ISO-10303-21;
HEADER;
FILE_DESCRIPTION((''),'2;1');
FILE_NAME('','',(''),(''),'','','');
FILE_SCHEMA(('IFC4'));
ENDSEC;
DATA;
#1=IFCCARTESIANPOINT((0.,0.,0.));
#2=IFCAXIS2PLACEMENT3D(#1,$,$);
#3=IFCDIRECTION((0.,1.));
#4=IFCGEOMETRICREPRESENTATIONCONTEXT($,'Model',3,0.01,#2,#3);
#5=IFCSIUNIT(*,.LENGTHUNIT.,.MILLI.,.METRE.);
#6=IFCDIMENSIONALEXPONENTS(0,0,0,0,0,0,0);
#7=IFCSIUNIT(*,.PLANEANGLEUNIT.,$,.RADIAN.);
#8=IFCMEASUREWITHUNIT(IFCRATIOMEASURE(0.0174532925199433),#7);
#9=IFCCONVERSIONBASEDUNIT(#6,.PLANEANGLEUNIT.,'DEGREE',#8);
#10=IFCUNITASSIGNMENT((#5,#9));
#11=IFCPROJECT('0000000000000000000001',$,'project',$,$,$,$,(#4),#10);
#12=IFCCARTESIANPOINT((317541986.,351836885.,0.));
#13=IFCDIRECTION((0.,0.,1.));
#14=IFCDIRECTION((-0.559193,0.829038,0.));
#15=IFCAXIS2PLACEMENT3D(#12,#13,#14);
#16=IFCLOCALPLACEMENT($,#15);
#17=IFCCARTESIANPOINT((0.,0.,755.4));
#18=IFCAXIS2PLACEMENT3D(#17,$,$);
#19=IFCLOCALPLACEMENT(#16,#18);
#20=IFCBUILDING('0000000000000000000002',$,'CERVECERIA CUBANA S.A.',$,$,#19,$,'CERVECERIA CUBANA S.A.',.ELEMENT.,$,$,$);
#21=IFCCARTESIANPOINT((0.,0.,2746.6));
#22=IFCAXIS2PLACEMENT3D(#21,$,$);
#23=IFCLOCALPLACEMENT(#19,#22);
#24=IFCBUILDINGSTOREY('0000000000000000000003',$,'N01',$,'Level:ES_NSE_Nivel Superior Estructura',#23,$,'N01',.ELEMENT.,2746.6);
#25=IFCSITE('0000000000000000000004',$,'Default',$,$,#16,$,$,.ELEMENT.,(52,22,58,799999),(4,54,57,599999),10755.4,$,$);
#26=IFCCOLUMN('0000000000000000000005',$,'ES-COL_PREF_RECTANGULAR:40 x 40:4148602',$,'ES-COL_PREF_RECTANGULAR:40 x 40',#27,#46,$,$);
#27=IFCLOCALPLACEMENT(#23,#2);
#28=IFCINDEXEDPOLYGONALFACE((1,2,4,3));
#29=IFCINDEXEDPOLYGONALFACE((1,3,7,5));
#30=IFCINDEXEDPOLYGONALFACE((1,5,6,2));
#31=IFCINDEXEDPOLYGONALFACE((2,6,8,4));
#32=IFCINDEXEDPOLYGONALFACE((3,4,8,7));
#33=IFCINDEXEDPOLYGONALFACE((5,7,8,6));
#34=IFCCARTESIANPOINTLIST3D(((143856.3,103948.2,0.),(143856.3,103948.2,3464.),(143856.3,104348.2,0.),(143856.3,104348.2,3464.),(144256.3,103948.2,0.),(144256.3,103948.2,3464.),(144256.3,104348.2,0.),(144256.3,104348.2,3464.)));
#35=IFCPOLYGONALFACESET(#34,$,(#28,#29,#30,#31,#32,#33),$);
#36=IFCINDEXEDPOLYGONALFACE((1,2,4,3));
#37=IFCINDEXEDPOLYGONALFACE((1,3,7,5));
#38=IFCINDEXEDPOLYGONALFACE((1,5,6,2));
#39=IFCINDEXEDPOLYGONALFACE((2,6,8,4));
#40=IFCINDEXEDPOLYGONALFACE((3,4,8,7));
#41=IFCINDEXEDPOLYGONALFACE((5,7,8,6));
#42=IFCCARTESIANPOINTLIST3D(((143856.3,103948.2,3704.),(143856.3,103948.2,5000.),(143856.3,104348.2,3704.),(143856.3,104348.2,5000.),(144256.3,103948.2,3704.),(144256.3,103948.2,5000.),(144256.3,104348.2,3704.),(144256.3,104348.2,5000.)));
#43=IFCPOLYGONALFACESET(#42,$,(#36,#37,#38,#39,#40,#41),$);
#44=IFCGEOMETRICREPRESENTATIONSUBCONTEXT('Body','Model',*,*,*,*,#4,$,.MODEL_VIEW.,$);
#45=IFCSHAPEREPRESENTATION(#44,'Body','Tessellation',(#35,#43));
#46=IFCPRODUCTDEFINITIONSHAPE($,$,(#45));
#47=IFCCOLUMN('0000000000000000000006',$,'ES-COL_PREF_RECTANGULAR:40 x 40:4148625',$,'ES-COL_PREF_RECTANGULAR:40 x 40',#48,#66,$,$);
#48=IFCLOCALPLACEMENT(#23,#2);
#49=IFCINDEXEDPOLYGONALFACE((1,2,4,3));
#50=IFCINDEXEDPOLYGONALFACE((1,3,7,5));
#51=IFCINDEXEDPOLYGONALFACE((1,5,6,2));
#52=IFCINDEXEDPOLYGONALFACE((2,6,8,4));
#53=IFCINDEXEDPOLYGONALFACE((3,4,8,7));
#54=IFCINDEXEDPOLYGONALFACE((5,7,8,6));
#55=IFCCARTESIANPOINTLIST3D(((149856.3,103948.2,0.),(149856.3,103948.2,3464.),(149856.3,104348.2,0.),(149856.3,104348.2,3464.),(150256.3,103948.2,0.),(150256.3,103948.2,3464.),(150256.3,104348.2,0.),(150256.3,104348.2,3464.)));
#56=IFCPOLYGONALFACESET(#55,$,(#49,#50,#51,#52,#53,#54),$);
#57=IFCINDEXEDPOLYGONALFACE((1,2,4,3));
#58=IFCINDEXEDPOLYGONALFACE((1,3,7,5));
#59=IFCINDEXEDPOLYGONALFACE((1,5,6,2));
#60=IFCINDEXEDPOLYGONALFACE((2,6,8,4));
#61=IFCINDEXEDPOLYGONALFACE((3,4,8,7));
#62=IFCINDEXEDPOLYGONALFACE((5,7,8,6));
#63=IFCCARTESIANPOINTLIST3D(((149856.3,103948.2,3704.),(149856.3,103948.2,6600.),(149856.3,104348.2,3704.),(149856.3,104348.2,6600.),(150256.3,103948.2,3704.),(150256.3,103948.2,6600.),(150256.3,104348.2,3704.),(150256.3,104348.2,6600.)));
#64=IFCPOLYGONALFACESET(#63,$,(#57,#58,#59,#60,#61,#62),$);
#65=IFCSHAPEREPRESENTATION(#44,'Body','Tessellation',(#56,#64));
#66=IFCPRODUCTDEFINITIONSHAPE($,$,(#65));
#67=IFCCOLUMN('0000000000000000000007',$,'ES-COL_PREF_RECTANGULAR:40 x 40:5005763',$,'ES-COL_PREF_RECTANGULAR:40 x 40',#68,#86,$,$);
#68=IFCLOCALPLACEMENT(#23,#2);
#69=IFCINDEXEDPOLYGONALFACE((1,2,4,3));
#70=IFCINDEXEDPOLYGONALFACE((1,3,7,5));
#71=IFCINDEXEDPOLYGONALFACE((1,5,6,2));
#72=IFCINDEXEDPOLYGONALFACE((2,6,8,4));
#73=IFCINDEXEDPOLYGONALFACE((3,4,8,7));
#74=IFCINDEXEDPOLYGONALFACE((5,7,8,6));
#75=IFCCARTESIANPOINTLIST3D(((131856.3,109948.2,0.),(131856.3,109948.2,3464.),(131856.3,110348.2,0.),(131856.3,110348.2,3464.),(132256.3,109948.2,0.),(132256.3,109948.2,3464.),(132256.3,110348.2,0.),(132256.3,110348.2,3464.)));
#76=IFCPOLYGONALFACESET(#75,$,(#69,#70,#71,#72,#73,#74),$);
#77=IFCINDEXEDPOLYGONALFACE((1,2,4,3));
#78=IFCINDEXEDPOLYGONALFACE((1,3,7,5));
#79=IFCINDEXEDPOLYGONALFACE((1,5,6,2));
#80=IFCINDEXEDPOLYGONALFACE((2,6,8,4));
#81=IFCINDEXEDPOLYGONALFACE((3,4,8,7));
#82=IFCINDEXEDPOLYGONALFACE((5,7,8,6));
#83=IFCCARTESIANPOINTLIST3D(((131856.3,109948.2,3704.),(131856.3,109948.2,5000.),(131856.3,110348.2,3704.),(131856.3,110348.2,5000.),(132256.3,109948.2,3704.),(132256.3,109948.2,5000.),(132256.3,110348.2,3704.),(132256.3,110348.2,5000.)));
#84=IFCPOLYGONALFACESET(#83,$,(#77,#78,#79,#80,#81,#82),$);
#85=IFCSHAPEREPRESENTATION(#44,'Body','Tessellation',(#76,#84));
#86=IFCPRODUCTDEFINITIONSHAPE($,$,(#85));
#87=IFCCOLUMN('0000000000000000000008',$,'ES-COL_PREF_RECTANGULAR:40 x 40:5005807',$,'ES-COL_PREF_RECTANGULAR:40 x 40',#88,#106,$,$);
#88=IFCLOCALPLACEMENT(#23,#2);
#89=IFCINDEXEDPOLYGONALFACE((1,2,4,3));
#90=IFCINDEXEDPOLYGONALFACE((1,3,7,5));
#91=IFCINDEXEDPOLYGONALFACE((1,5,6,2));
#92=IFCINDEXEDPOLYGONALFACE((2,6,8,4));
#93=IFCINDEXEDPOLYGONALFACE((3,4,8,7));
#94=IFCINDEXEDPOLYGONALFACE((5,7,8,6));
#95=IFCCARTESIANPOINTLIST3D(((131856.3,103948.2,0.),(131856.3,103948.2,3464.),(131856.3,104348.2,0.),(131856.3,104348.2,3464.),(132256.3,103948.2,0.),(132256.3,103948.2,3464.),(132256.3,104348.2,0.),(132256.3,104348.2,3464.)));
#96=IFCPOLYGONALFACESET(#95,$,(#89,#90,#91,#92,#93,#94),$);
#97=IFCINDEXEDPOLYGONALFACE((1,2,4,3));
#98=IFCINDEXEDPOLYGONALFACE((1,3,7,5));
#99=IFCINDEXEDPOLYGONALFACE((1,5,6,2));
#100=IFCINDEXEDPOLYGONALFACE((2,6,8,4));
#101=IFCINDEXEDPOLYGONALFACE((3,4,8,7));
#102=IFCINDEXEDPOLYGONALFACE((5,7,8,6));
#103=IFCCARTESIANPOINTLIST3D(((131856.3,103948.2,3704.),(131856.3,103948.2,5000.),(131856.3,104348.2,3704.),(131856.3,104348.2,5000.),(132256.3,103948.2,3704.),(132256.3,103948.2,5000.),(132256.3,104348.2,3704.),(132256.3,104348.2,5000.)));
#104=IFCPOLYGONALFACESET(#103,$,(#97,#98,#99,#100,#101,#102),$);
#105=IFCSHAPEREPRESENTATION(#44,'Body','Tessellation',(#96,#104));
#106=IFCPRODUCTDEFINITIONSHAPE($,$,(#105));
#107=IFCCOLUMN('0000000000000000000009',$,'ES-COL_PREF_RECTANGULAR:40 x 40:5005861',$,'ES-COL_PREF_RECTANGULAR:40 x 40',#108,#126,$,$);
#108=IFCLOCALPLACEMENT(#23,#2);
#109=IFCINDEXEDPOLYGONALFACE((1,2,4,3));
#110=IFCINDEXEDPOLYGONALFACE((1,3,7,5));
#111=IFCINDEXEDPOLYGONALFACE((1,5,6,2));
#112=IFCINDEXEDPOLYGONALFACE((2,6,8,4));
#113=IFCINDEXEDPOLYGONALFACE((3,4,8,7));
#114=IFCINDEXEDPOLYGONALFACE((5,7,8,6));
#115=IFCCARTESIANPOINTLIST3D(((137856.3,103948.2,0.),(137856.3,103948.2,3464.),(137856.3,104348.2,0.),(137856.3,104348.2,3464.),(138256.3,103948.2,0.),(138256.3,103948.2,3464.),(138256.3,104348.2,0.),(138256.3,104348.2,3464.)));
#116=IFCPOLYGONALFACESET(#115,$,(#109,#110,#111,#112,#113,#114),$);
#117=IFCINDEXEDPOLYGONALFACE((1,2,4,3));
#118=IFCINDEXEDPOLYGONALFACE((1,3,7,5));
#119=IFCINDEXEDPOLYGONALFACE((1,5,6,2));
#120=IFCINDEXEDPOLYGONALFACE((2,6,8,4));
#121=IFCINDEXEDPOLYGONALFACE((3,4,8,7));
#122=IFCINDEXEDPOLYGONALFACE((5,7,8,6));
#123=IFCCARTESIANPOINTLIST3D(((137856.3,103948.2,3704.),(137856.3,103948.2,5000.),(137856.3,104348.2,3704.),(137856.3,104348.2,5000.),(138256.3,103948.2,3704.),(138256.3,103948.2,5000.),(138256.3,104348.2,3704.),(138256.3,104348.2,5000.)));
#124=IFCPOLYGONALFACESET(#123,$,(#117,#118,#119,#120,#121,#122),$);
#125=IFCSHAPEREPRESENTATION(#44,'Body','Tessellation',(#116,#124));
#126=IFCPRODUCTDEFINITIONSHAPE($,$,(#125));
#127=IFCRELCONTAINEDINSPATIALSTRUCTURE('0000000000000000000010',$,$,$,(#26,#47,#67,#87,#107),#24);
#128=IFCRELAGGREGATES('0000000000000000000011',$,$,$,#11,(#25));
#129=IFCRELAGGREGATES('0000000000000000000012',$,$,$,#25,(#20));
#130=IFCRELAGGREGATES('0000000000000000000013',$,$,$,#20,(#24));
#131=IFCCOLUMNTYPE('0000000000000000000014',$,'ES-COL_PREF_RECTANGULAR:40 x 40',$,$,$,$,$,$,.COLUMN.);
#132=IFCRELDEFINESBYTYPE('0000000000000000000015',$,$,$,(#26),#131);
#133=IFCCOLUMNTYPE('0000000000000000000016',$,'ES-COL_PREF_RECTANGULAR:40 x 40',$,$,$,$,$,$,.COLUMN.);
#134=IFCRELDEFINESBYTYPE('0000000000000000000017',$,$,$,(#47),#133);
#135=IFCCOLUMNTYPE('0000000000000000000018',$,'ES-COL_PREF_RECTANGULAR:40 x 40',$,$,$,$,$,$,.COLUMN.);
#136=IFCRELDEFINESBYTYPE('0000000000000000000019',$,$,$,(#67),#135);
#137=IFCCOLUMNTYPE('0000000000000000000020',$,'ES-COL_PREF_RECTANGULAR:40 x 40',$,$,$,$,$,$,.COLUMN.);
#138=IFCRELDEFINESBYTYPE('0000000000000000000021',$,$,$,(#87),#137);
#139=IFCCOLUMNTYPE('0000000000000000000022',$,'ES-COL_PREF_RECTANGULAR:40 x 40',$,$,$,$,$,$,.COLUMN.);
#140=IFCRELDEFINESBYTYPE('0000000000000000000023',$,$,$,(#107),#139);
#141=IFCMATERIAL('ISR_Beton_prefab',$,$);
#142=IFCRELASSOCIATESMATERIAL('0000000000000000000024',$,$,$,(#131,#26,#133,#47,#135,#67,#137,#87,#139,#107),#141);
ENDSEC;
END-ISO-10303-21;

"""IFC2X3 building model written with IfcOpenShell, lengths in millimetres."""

from ifc_helpers import new_model, entity, si_unit, converted_unit, direction, frame, frame_2d, origin, origin_2d_with_axis, place, context, subcontext, project, spatial, rectangle, extrude, source, transform, mapped, material, type_object, type_shapes, element, save


model = new_model("IFC2X3")

# Units and contexts
model_context = context("Model", 3, precision=0.01, world=origin(), true_north=direction((0.0, 1.0)))
body_context = subcontext(model_context, "Body", "Model", "MODEL_VIEW")
ifc_project = project(units=[si_unit("LENGTHUNIT", "METRE", prefix="MILLI"), converted_unit("PLANEANGLEUNIT", "DEGREE", entity("IfcRatioMeasure", 0.0174532925199433), si_unit("PLANEANGLEUNIT", "RADIAN"), dimensions=[0, 0, 0, 0, 0, 0, 0])], contexts=[model_context])

# Site, building, storey
site_placement = place(None, frame((317541986.0, 351836885.0, 0.0), z_axis=(0.0, 0.0, 1.0), x_axis=(-0.559193, 0.829038, 0.0)))
site = spatial("IfcSite", under=ifc_project, at=site_placement, Name="Default", CompositionType="ELEMENT", RefLatitude=(52, 22, 58, 799999), RefLongitude=(4, 54, 57, 599999), RefElevation=10755.4)
building_placement = place(site_placement, frame((0.0, 0.0, 755.4)))
building = spatial("IfcBuilding", under=site, at=building_placement, Name="CERVECERIA CUBANA S.A.", LongName="CERVECERIA CUBANA S.A.", CompositionType="ELEMENT")
storey_placement = place(building_placement, frame((0.0, 0.0, 2746.6)))
storey = spatial("IfcBuildingStorey", under=building, at=storey_placement, Name="N01", ObjectType="Level:ES_NSE_Nivel Superior Estructura", LongName="N01", CompositionType="ELEMENT", Elevation=2746.6)

# Columns
ifc_material_1 = material(Name="ISR_Beton_prefab")
column_type_1 = type_object("IfcColumnType", Name="ES-COL_PREF_RECTANGULAR:40 x 40", PredefinedType="COLUMN", material=ifc_material_1)
shared_shape_1 = source(origin(), body_context, "Body", "SweptSolid", [
    extrude(rectangle(XDim=400.0, YDim=400.0, at=frame_2d((0.0, 0.0), x_axis=(1.0, 0.0))), frame((144056.3, 104148.2, 2746.6), z_axis=(0.0, 0.0, 1.0), x_axis=(0.0, -1.0, 0.0)), (0.0, 0.0, 1.0), 3464.0),
    extrude(rectangle(XDim=400.0, YDim=400.0, at=frame_2d((0.0, 0.0), x_axis=(1.0, 0.0))), frame((144056.3, 104148.2, 6450.6), z_axis=(0.0, 0.0, 1.0), x_axis=(0.0, -1.0, 0.0)), (0.0, 0.0, 1.0), 1296.0),
])
type_shapes(column_type_1, [shared_shape_1])
column_1_placement = place(storey_placement, frame((0.0, 0.0, -2746.6)))
element("IfcColumn", 1, at=column_1_placement, inside=storey, type_object=column_type_1, material=ifc_material_1, Name="ES-COL_PREF_RECTANGULAR:40 x 40:4148602", ObjectType="ES-COL_PREF_RECTANGULAR:40 x 40", context=body_context, shape_type="MappedRepresentation", body=[
    mapped(shared_shape_1, transform((0.0, 0.0, 0.0), scale=1.0)),
])
column_type_2 = type_object("IfcColumnType", Name="ES-COL_PREF_RECTANGULAR:40 x 40", PredefinedType="COLUMN", material=ifc_material_1)
shared_shape_2 = source(origin(), body_context, "Body", "SweptSolid", [
    extrude(rectangle(XDim=400.0, YDim=400.0, at=origin_2d_with_axis()), frame((150056.3, 104148.2, 2746.6), z_axis=(0.0, 0.0, 1.0), x_axis=(0.0, -1.0, 0.0)), (0.0, 0.0, 1.0), 3464.0),
    extrude(rectangle(XDim=400.0, YDim=400.0, at=origin_2d_with_axis()), frame((150056.3, 104148.2, 6450.6), z_axis=(0.0, 0.0, 1.0), x_axis=(0.0, -1.0, 0.0)), (0.0, 0.0, 1.0), 2896.0),
])
type_shapes(column_type_2, [shared_shape_2])
column_2_placement = place(storey_placement, frame((0.0, 0.0, -2746.6)))
element("IfcColumn", 2, at=column_2_placement, inside=storey, type_object=column_type_2, material=ifc_material_1, Name="ES-COL_PREF_RECTANGULAR:40 x 40:4148625", ObjectType="ES-COL_PREF_RECTANGULAR:40 x 40", context=body_context, shape_type="MappedRepresentation", body=[
    mapped(shared_shape_2, transform((0.0, 0.0, 0.0), scale=1.0)),
])
column_type_3 = type_object("IfcColumnType", Name="ES-COL_PREF_RECTANGULAR:40 x 40", PredefinedType="COLUMN", material=ifc_material_1)
shared_shape_3 = source(origin(), body_context, "Body", "SweptSolid", [
    extrude(rectangle(XDim=400.0, YDim=400.0, at=frame_2d((0.0, 0.0), x_axis=(1.0, 0.0))), frame((132056.3, 110148.2, 2746.6), z_axis=(0.0, 0.0, 1.0), x_axis=(0.0, -1.0, 0.0)), (0.0, 0.0, 1.0), 3464.0),
    extrude(rectangle(XDim=400.0, YDim=400.0, at=frame_2d((0.0, 0.0), x_axis=(1.0, 0.0))), frame((132056.3, 110148.2, 6450.6), z_axis=(0.0, 0.0, 1.0), x_axis=(0.0, -1.0, 0.0)), (0.0, 0.0, 1.0), 1296.0),
])
type_shapes(column_type_3, [shared_shape_3])
column_3_placement = place(storey_placement, frame((0.0, 0.0, -2746.6)))
element("IfcColumn", 3, at=column_3_placement, inside=storey, type_object=column_type_3, material=ifc_material_1, Name="ES-COL_PREF_RECTANGULAR:40 x 40:5005763", ObjectType="ES-COL_PREF_RECTANGULAR:40 x 40", context=body_context, shape_type="MappedRepresentation", body=[
    mapped(shared_shape_3, transform((0.0, 0.0, 0.0), scale=1.0)),
])
column_type_4 = type_object("IfcColumnType", Name="ES-COL_PREF_RECTANGULAR:40 x 40", PredefinedType="COLUMN", material=ifc_material_1)
shared_shape_4 = source(origin(), body_context, "Body", "SweptSolid", [
    extrude(rectangle(XDim=400.0, YDim=400.0, at=origin_2d_with_axis()), frame((132056.3, 104148.2, 2746.6), z_axis=(0.0, 0.0, 1.0), x_axis=(0.0, -1.0, 0.0)), (0.0, 0.0, 1.0), 3464.0),
    extrude(rectangle(XDim=400.0, YDim=400.0, at=origin_2d_with_axis()), frame((132056.3, 104148.2, 6450.6), z_axis=(0.0, 0.0, 1.0), x_axis=(0.0, -1.0, 0.0)), (0.0, 0.0, 1.0), 1296.0),
])
type_shapes(column_type_4, [shared_shape_4])
column_4_placement = place(storey_placement, frame((0.0, 0.0, -2746.6)))
element("IfcColumn", 4, at=column_4_placement, inside=storey, type_object=column_type_4, material=ifc_material_1, Name="ES-COL_PREF_RECTANGULAR:40 x 40:5005807", ObjectType="ES-COL_PREF_RECTANGULAR:40 x 40", context=body_context, shape_type="MappedRepresentation", body=[
    mapped(shared_shape_4, transform((0.0, 0.0, 0.0), scale=1.0)),
])
column_type_5 = type_object("IfcColumnType", Name="ES-COL_PREF_RECTANGULAR:40 x 40", PredefinedType="COLUMN", material=ifc_material_1)
shared_shape_5 = source(origin(), body_context, "Body", "SweptSolid", [
    extrude(rectangle(XDim=400.0, YDim=400.0, at=origin_2d_with_axis()), frame((138056.3, 104148.2, 2746.6), z_axis=(0.0, 0.0, 1.0), x_axis=(0.0, -1.0, 0.0)), (0.0, 0.0, 1.0), 3464.0),
    extrude(rectangle(XDim=400.0, YDim=400.0, at=origin_2d_with_axis()), frame((138056.3, 104148.2, 6450.6), z_axis=(0.0, 0.0, 1.0), x_axis=(0.0, -1.0, 0.0)), (0.0, 0.0, 1.0), 1296.0),
])
type_shapes(column_type_5, [shared_shape_5])
column_5_placement = place(storey_placement, frame((0.0, 0.0, -2746.6)))
element("IfcColumn", 5, at=column_5_placement, inside=storey, type_object=column_type_5, material=ifc_material_1, Name="ES-COL_PREF_RECTANGULAR:40 x 40:5005861", ObjectType="ES-COL_PREF_RECTANGULAR:40 x 40", context=body_context, shape_type="MappedRepresentation", body=[
    mapped(shared_shape_5, transform((0.0, 0.0, 0.0), scale=1.0)),
])

save(model, "model.ifc")
